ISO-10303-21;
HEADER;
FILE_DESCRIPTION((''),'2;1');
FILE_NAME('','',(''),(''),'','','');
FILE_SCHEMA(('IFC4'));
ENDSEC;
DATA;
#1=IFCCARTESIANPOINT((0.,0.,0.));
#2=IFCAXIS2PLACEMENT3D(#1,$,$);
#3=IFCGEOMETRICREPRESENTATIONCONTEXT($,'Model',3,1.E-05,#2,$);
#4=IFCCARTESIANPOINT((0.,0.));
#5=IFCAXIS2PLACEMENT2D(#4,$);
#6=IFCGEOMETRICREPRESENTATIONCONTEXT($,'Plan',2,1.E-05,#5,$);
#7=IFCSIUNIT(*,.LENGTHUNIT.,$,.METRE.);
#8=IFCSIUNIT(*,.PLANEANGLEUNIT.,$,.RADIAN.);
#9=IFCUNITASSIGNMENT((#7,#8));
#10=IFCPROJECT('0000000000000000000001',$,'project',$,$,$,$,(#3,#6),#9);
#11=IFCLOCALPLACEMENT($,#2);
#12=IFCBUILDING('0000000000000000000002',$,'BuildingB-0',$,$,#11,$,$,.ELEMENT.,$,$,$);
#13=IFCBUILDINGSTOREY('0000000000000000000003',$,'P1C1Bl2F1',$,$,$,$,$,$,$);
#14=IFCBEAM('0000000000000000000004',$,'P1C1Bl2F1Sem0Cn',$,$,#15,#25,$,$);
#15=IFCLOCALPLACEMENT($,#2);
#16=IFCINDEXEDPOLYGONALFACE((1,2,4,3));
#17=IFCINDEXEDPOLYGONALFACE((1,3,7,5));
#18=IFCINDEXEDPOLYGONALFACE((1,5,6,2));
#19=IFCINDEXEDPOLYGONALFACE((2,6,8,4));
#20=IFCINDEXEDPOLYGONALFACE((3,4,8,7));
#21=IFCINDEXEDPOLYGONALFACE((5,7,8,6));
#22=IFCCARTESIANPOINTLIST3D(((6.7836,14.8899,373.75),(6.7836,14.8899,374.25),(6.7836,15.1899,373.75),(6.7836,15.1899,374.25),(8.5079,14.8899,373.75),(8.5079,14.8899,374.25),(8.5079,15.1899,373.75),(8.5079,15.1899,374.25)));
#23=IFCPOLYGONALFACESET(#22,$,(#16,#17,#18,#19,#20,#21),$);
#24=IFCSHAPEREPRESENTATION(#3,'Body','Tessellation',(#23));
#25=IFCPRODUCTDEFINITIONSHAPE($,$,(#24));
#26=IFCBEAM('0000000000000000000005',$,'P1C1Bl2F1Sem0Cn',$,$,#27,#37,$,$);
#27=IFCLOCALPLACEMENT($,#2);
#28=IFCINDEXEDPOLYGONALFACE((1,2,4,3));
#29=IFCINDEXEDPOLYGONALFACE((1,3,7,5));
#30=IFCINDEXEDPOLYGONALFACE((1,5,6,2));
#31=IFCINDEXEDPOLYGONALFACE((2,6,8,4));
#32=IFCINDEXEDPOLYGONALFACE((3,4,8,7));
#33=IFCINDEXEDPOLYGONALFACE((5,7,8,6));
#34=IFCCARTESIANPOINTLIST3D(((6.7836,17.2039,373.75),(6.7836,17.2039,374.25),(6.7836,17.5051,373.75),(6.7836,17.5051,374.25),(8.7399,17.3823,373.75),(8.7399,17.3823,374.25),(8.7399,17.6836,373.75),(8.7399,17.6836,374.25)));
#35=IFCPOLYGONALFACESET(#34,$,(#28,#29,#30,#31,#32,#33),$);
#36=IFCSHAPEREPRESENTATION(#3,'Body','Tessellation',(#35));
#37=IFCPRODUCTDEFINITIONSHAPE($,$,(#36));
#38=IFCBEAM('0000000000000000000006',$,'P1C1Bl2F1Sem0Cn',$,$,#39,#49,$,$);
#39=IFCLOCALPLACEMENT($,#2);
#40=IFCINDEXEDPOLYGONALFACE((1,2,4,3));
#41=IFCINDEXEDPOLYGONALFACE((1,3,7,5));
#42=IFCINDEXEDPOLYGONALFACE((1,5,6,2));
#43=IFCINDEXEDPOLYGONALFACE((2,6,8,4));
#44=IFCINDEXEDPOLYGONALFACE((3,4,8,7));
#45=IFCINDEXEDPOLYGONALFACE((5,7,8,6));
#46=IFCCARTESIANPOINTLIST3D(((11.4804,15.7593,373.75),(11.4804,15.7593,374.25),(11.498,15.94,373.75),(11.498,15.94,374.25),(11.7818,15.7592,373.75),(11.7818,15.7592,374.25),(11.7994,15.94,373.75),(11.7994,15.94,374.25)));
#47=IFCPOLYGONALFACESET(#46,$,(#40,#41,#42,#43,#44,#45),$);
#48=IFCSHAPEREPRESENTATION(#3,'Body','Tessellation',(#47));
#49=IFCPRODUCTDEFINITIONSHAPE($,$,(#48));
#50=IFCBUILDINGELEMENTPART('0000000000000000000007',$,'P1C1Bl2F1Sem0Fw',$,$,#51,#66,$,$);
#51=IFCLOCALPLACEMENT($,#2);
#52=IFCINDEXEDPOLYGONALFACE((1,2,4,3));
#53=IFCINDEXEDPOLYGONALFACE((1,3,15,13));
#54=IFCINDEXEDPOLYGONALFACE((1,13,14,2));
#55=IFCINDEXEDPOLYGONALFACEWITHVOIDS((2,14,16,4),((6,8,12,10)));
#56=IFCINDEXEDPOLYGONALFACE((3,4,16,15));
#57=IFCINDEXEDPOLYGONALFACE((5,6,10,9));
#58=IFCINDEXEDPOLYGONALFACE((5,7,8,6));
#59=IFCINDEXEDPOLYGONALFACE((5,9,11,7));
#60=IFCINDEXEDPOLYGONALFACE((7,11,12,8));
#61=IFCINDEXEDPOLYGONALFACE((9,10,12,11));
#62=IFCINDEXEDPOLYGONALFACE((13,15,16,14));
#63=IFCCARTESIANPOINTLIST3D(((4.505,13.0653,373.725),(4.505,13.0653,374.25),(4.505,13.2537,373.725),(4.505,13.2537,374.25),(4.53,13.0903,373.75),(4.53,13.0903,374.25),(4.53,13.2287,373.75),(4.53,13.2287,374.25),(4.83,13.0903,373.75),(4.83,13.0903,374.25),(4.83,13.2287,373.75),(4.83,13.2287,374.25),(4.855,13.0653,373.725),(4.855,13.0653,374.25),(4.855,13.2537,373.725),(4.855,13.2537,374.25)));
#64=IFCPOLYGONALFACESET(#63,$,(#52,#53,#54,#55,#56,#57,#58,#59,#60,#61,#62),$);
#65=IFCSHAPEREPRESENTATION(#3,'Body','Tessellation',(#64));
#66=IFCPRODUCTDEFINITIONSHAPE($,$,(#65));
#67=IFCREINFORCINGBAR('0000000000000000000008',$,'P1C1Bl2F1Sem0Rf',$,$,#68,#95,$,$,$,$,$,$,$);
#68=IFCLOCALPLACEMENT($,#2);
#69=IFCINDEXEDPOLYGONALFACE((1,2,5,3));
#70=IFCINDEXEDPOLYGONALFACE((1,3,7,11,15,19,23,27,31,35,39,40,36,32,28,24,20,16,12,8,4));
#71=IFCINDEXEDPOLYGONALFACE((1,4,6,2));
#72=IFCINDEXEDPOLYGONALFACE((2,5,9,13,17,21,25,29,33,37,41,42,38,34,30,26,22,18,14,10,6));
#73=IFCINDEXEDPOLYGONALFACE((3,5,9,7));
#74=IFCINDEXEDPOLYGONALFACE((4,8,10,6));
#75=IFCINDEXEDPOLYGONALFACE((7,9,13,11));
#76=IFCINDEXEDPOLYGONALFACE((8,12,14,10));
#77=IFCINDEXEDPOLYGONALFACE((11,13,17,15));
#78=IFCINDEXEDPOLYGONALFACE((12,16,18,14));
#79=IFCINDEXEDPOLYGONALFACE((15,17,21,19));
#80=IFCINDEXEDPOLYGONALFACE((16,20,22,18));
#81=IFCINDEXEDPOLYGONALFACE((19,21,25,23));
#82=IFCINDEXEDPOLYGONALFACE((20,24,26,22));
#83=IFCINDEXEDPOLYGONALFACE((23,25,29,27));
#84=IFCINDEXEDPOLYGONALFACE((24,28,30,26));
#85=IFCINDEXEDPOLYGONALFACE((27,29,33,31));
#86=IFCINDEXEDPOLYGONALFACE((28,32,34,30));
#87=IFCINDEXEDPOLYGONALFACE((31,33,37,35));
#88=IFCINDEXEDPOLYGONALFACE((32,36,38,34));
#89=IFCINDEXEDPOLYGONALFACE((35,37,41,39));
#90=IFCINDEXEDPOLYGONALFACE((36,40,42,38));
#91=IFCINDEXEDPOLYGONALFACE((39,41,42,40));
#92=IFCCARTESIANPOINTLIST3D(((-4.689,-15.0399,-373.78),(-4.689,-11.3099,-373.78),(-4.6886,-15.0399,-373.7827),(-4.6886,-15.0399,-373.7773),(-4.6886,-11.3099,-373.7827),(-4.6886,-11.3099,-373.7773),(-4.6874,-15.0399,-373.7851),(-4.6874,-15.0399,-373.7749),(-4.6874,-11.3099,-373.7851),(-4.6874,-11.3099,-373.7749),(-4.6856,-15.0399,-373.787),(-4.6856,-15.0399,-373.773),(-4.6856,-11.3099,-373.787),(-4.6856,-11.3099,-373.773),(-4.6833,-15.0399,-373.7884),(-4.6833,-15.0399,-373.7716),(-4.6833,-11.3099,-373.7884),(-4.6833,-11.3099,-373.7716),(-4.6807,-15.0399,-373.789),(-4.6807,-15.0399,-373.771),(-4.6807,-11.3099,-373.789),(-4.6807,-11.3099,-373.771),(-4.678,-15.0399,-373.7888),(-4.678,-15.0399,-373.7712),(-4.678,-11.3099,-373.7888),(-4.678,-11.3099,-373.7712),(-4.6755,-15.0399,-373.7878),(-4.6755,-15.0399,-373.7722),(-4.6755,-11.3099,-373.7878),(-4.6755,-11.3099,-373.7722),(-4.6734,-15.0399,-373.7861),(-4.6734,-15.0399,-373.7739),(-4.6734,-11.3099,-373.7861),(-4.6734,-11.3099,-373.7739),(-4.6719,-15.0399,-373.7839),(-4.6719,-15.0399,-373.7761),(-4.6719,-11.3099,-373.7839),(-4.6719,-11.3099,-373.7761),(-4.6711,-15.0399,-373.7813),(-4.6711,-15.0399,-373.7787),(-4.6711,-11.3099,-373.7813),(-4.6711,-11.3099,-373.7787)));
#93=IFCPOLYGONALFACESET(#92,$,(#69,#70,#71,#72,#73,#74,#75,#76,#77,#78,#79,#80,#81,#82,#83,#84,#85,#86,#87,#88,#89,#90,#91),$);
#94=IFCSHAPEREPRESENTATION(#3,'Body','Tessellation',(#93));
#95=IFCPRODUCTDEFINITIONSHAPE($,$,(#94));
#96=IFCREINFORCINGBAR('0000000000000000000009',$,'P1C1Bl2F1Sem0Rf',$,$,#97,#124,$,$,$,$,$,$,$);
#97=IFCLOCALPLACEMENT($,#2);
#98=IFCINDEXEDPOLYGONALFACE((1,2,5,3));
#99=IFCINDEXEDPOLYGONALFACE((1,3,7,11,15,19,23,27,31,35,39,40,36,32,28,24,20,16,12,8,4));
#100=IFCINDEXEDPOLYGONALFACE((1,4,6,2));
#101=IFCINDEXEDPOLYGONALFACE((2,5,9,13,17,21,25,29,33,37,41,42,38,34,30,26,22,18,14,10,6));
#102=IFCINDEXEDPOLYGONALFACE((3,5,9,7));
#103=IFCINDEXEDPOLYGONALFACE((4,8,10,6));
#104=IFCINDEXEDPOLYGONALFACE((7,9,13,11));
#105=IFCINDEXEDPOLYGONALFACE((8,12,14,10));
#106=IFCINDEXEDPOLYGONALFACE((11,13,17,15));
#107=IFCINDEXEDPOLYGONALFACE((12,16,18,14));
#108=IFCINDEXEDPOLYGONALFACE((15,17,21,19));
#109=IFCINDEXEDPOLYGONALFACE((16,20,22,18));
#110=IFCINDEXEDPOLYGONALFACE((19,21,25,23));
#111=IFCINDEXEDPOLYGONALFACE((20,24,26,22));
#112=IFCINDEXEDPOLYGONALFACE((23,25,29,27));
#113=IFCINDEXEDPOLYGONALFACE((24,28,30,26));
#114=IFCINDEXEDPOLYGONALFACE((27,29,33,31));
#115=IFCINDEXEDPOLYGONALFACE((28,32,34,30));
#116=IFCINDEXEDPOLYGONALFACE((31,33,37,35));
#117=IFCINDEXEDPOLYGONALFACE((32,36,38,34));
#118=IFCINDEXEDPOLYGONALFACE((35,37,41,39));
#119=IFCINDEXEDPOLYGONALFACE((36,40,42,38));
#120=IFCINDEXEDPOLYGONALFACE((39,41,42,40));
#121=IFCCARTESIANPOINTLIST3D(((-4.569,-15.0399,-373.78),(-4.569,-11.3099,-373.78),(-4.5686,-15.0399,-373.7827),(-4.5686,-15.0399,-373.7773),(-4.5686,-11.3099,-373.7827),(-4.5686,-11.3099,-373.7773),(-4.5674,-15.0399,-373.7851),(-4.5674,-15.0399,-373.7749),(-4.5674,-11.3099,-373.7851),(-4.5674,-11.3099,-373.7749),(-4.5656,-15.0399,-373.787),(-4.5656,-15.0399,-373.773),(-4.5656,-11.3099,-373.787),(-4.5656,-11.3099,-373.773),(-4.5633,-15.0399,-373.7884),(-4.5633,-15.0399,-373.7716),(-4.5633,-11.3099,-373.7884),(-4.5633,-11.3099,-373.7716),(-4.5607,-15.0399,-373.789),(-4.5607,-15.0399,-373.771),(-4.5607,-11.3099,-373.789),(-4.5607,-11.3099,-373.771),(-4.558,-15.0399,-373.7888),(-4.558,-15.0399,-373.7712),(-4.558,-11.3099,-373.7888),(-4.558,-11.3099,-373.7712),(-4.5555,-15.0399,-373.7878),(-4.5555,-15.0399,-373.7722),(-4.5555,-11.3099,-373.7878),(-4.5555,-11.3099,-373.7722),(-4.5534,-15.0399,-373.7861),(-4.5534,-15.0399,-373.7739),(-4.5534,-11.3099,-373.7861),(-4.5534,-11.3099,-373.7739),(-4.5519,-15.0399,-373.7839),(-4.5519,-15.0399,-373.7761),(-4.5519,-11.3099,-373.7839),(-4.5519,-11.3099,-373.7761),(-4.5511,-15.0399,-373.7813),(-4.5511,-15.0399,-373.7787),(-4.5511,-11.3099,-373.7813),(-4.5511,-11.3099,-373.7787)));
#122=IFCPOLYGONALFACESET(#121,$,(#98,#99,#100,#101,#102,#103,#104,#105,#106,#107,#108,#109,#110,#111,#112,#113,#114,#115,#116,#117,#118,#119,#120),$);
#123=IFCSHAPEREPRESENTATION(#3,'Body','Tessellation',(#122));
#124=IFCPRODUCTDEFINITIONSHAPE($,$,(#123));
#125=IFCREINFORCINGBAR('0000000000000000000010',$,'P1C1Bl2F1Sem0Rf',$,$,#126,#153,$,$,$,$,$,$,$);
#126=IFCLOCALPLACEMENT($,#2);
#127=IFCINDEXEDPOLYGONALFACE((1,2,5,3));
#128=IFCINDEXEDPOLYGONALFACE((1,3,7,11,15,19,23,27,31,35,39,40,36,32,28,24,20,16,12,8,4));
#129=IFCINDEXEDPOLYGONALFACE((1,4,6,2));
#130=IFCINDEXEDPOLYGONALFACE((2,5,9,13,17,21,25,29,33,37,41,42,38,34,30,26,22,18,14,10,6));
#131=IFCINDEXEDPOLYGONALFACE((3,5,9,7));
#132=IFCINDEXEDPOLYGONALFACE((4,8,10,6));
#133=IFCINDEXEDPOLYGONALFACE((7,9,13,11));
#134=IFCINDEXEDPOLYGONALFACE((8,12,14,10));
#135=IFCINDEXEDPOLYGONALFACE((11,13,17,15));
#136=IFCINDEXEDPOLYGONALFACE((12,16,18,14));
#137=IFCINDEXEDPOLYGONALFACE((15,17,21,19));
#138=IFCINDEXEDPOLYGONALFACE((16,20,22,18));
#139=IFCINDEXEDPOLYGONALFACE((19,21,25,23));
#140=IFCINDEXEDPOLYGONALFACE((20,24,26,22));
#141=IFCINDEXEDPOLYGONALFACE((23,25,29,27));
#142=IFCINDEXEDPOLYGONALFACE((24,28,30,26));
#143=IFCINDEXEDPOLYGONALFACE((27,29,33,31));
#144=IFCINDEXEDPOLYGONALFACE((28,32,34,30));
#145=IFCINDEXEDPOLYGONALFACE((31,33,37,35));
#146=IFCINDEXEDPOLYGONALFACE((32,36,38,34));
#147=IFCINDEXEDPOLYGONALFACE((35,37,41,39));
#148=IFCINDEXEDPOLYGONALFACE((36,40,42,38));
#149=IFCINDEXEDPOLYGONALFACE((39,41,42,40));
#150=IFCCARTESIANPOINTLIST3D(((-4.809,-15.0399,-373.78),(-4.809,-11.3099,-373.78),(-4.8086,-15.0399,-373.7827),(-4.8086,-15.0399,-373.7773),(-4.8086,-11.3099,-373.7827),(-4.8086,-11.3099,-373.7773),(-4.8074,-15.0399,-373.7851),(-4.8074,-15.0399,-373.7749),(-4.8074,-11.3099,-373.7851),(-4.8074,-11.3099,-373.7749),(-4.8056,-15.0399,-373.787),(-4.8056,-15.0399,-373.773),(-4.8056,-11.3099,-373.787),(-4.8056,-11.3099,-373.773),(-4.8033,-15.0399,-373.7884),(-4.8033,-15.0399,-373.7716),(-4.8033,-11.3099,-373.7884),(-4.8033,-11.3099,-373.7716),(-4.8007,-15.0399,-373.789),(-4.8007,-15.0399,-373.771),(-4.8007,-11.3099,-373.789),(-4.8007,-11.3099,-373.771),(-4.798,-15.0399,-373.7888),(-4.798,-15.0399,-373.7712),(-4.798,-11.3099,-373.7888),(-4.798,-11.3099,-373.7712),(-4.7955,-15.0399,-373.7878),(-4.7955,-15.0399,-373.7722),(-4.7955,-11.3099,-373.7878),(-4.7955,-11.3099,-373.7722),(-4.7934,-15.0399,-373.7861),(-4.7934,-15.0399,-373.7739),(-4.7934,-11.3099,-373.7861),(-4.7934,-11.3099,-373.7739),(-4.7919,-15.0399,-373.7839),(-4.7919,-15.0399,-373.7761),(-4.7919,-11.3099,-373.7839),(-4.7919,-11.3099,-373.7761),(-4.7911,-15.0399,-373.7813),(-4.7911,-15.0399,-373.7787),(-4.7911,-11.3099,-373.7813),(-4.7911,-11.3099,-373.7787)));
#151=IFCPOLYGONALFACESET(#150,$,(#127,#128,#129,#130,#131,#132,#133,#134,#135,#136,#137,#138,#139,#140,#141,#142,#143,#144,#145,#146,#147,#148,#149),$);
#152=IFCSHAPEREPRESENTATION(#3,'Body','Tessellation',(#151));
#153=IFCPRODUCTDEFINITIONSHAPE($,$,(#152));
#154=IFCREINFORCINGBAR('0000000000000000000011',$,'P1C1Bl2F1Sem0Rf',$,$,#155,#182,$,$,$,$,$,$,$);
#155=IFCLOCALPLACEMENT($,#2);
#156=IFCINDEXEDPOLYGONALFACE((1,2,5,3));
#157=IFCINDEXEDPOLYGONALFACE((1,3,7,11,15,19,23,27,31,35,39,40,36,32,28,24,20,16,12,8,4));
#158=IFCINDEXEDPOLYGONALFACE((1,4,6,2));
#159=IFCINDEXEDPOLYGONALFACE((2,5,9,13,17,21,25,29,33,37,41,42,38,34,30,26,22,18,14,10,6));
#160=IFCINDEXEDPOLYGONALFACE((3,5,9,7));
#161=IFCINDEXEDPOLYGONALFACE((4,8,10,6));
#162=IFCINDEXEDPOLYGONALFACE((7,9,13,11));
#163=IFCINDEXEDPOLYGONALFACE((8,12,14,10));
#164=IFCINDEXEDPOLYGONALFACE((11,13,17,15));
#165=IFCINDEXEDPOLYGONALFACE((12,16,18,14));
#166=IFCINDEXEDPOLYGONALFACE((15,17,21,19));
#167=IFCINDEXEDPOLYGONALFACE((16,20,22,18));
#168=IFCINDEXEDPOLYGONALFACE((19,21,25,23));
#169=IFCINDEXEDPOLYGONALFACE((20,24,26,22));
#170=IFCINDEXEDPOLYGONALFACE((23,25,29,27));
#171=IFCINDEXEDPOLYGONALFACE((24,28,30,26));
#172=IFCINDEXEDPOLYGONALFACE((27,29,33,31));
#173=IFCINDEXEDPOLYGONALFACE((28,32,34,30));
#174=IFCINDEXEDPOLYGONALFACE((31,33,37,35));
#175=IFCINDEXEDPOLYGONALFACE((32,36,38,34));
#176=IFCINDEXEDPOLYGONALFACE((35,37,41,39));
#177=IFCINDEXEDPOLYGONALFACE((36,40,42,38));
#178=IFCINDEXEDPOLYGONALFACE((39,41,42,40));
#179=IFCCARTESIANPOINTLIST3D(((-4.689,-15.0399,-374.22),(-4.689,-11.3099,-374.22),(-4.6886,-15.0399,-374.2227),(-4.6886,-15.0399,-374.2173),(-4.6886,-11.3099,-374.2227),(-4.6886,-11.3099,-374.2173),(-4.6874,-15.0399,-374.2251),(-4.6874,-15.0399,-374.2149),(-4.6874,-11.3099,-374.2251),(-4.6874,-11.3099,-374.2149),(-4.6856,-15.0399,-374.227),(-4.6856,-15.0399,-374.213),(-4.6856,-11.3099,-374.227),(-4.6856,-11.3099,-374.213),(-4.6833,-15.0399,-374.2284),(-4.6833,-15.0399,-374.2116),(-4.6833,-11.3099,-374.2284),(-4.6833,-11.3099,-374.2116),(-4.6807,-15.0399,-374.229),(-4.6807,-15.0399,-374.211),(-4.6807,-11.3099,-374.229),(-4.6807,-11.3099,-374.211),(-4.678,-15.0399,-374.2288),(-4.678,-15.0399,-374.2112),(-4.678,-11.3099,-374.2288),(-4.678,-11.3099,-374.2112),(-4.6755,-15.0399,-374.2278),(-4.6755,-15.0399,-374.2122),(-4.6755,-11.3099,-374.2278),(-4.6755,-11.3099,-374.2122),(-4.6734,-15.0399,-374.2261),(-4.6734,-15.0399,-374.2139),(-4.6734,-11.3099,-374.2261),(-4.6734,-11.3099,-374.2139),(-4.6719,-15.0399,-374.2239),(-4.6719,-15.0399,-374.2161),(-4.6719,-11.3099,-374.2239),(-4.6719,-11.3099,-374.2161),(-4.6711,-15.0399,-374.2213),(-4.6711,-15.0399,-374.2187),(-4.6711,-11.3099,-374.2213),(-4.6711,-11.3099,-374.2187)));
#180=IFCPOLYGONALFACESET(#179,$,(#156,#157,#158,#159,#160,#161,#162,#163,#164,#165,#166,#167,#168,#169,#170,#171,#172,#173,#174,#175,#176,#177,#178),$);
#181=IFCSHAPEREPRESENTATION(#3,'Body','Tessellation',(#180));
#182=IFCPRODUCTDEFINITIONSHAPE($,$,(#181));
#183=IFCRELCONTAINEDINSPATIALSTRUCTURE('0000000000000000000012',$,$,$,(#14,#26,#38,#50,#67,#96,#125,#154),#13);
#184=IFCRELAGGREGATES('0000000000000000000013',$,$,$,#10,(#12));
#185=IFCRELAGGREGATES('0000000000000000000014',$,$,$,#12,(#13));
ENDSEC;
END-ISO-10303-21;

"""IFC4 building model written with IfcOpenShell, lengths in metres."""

from ifc_helpers import new_model, entity, si_unit, origin, origin_2d, place, context, project, spatial, polyline, outline, extrude, element, save


model = new_model("IFC4")

# Units and contexts
model_context = context("Model", 3, precision=1e-05, world=origin())
plan_context = context("Plan", 2, precision=1e-05, world=origin_2d())
ifc_project = project(units=[si_unit("LENGTHUNIT", "METRE"), si_unit("PLANEANGLEUNIT", "RADIAN")], contexts=[model_context, plan_context])

# Building, storey
building_placement = place(None, origin())
building = spatial("IfcBuilding", under=ifc_project, at=building_placement, Name="BuildingB-0", CompositionType="ELEMENT")
storey = spatial("IfcBuildingStorey", under=building, Name="P1C1Bl2F1")

# Beams
element("IfcBeam", 1, inside=storey, Name="P1C1Bl2F1Sem0Cn", context=model_context, shape_type="SweptSolid", body=[
    extrude(outline(polyline([(6.7836, 14.8899, 373.75), (6.7836, 15.1899, 373.75), (8.5079, 15.1899, 373.75), (8.5079, 14.8899, 373.75), (6.7836, 14.8899, 373.75)])), None, (0.0, 0.0, 1.0), 0.5),
])
element("IfcBeam", 2, inside=storey, Name="P1C1Bl2F1Sem0Cn", context=model_context, shape_type="SweptSolid", body=[
    extrude(outline(polyline([(6.7836, 17.2039, 373.75), (6.7836, 17.5051, 373.75), (8.7399, 17.6836, 373.75), (8.7399, 17.3823, 373.75), (6.7836, 17.2039, 373.75)])), None, (0.0, 0.0, 1.0), 0.5),
])
element("IfcBeam", 3, inside=storey, Name="P1C1Bl2F1Sem0Cn", context=model_context, shape_type="SweptSolid", body=[
    extrude(outline(polyline([(11.4804, 15.7593, 373.75), (11.498, 15.94, 373.75), (11.7994, 15.94, 373.75), (11.7818, 15.7592, 373.75), (11.4804, 15.7593, 373.75)])), None, (0.0, 0.0, 1.0), 0.5),
])

# Building element part, opening
building_element_part_1 = element("IfcBuildingElementPart", 4, inside=storey, Name="P1C1Bl2F1Sem0Fw", context=model_context, shape_type="SweptSolid", body=[
    extrude(outline(polyline([(4.505, 13.0653, 373.725), (4.505, 13.2537, 373.725), (4.855, 13.2537, 373.725), (4.855, 13.0653, 373.725), (4.505, 13.0653, 373.725)])), None, (0.0, 0.0, 1.0), 0.525),
])
element("IfcOpeningElement", 5, inside=storey, cuts=building_element_part_1, context=model_context, shape_type="SweptSolid", body=[
    extrude(outline(polyline([(4.53, 13.0903, 373.75), (4.53, 13.2287, 373.75), (4.83, 13.2287, 373.75), (4.83, 13.0903, 373.75), (4.53, 13.0903, 373.75)])), None, (0.0, 0.0, 1.0), 0.5),
])

# Reinforcing bars
element("IfcReinforcingBar", 6, inside=storey, Name="P1C1Bl2F1Sem0Rf", context=model_context, shape_type="SweptSolid", body=[
    entity("IfcSurfaceCurveSweptAreaSolid", entity("IfcCircleProfileDef", "AREA", None, None, 0.009), None, entity("IfcPolyline", [entity("IfcCartesianPoint", [4.68, 15.0399, 373.78]), entity("IfcCartesianPoint", [4.68, 11.3099, 373.78])]), None, None, entity("IfcPlane", entity("IfcAxis2Placement3D", entity("IfcCartesianPoint", [4.68, 15.0399, 373.78]), entity("IfcDirection", [0.0, 0.0, 1.0]), entity("IfcDirection", [1.0, 0.0, 0.0])))),
])
element("IfcReinforcingBar", 7, inside=storey, Name="P1C1Bl2F1Sem0Rf", context=model_context, shape_type="SweptSolid", body=[
    entity("IfcSurfaceCurveSweptAreaSolid", entity("IfcCircleProfileDef", "AREA", None, None, 0.009), None, entity("IfcPolyline", [entity("IfcCartesianPoint", [4.56, 15.0399, 373.78]), entity("IfcCartesianPoint", [4.56, 11.3099, 373.78])]), None, None, entity("IfcPlane", entity("IfcAxis2Placement3D", entity("IfcCartesianPoint", [4.56, 15.0399, 373.78]), entity("IfcDirection", [0.0, 0.0, 1.0]), entity("IfcDirection", [1.0, 0.0, 0.0])))),
])
element("IfcReinforcingBar", 8, inside=storey, Name="P1C1Bl2F1Sem0Rf", context=model_context, shape_type="SweptSolid", body=[
    entity("IfcSurfaceCurveSweptAreaSolid", entity("IfcCircleProfileDef", "AREA", None, None, 0.009), None, entity("IfcPolyline", [entity("IfcCartesianPoint", [4.8, 15.0399, 373.78]), entity("IfcCartesianPoint", [4.8, 11.3099, 373.78])]), None, None, entity("IfcPlane", entity("IfcAxis2Placement3D", entity("IfcCartesianPoint", [4.8, 15.0399, 373.78]), entity("IfcDirection", [0.0, 0.0, 1.0]), entity("IfcDirection", [1.0, 0.0, 0.0])))),
])
element("IfcReinforcingBar", 9, inside=storey, Name="P1C1Bl2F1Sem0Rf", context=model_context, shape_type="SweptSolid", body=[
    entity("IfcSurfaceCurveSweptAreaSolid", entity("IfcCircleProfileDef", "AREA", None, None, 0.009), None, entity("IfcPolyline", [entity("IfcCartesianPoint", [4.68, 15.0399, 374.22]), entity("IfcCartesianPoint", [4.68, 11.3099, 374.22])]), None, None, entity("IfcPlane", entity("IfcAxis2Placement3D", entity("IfcCartesianPoint", [4.68, 15.0399, 374.22]), entity("IfcDirection", [0.0, 0.0, 1.0]), entity("IfcDirection", [1.0, 0.0, 0.0])))),
])

save(model, "model.ifc")
